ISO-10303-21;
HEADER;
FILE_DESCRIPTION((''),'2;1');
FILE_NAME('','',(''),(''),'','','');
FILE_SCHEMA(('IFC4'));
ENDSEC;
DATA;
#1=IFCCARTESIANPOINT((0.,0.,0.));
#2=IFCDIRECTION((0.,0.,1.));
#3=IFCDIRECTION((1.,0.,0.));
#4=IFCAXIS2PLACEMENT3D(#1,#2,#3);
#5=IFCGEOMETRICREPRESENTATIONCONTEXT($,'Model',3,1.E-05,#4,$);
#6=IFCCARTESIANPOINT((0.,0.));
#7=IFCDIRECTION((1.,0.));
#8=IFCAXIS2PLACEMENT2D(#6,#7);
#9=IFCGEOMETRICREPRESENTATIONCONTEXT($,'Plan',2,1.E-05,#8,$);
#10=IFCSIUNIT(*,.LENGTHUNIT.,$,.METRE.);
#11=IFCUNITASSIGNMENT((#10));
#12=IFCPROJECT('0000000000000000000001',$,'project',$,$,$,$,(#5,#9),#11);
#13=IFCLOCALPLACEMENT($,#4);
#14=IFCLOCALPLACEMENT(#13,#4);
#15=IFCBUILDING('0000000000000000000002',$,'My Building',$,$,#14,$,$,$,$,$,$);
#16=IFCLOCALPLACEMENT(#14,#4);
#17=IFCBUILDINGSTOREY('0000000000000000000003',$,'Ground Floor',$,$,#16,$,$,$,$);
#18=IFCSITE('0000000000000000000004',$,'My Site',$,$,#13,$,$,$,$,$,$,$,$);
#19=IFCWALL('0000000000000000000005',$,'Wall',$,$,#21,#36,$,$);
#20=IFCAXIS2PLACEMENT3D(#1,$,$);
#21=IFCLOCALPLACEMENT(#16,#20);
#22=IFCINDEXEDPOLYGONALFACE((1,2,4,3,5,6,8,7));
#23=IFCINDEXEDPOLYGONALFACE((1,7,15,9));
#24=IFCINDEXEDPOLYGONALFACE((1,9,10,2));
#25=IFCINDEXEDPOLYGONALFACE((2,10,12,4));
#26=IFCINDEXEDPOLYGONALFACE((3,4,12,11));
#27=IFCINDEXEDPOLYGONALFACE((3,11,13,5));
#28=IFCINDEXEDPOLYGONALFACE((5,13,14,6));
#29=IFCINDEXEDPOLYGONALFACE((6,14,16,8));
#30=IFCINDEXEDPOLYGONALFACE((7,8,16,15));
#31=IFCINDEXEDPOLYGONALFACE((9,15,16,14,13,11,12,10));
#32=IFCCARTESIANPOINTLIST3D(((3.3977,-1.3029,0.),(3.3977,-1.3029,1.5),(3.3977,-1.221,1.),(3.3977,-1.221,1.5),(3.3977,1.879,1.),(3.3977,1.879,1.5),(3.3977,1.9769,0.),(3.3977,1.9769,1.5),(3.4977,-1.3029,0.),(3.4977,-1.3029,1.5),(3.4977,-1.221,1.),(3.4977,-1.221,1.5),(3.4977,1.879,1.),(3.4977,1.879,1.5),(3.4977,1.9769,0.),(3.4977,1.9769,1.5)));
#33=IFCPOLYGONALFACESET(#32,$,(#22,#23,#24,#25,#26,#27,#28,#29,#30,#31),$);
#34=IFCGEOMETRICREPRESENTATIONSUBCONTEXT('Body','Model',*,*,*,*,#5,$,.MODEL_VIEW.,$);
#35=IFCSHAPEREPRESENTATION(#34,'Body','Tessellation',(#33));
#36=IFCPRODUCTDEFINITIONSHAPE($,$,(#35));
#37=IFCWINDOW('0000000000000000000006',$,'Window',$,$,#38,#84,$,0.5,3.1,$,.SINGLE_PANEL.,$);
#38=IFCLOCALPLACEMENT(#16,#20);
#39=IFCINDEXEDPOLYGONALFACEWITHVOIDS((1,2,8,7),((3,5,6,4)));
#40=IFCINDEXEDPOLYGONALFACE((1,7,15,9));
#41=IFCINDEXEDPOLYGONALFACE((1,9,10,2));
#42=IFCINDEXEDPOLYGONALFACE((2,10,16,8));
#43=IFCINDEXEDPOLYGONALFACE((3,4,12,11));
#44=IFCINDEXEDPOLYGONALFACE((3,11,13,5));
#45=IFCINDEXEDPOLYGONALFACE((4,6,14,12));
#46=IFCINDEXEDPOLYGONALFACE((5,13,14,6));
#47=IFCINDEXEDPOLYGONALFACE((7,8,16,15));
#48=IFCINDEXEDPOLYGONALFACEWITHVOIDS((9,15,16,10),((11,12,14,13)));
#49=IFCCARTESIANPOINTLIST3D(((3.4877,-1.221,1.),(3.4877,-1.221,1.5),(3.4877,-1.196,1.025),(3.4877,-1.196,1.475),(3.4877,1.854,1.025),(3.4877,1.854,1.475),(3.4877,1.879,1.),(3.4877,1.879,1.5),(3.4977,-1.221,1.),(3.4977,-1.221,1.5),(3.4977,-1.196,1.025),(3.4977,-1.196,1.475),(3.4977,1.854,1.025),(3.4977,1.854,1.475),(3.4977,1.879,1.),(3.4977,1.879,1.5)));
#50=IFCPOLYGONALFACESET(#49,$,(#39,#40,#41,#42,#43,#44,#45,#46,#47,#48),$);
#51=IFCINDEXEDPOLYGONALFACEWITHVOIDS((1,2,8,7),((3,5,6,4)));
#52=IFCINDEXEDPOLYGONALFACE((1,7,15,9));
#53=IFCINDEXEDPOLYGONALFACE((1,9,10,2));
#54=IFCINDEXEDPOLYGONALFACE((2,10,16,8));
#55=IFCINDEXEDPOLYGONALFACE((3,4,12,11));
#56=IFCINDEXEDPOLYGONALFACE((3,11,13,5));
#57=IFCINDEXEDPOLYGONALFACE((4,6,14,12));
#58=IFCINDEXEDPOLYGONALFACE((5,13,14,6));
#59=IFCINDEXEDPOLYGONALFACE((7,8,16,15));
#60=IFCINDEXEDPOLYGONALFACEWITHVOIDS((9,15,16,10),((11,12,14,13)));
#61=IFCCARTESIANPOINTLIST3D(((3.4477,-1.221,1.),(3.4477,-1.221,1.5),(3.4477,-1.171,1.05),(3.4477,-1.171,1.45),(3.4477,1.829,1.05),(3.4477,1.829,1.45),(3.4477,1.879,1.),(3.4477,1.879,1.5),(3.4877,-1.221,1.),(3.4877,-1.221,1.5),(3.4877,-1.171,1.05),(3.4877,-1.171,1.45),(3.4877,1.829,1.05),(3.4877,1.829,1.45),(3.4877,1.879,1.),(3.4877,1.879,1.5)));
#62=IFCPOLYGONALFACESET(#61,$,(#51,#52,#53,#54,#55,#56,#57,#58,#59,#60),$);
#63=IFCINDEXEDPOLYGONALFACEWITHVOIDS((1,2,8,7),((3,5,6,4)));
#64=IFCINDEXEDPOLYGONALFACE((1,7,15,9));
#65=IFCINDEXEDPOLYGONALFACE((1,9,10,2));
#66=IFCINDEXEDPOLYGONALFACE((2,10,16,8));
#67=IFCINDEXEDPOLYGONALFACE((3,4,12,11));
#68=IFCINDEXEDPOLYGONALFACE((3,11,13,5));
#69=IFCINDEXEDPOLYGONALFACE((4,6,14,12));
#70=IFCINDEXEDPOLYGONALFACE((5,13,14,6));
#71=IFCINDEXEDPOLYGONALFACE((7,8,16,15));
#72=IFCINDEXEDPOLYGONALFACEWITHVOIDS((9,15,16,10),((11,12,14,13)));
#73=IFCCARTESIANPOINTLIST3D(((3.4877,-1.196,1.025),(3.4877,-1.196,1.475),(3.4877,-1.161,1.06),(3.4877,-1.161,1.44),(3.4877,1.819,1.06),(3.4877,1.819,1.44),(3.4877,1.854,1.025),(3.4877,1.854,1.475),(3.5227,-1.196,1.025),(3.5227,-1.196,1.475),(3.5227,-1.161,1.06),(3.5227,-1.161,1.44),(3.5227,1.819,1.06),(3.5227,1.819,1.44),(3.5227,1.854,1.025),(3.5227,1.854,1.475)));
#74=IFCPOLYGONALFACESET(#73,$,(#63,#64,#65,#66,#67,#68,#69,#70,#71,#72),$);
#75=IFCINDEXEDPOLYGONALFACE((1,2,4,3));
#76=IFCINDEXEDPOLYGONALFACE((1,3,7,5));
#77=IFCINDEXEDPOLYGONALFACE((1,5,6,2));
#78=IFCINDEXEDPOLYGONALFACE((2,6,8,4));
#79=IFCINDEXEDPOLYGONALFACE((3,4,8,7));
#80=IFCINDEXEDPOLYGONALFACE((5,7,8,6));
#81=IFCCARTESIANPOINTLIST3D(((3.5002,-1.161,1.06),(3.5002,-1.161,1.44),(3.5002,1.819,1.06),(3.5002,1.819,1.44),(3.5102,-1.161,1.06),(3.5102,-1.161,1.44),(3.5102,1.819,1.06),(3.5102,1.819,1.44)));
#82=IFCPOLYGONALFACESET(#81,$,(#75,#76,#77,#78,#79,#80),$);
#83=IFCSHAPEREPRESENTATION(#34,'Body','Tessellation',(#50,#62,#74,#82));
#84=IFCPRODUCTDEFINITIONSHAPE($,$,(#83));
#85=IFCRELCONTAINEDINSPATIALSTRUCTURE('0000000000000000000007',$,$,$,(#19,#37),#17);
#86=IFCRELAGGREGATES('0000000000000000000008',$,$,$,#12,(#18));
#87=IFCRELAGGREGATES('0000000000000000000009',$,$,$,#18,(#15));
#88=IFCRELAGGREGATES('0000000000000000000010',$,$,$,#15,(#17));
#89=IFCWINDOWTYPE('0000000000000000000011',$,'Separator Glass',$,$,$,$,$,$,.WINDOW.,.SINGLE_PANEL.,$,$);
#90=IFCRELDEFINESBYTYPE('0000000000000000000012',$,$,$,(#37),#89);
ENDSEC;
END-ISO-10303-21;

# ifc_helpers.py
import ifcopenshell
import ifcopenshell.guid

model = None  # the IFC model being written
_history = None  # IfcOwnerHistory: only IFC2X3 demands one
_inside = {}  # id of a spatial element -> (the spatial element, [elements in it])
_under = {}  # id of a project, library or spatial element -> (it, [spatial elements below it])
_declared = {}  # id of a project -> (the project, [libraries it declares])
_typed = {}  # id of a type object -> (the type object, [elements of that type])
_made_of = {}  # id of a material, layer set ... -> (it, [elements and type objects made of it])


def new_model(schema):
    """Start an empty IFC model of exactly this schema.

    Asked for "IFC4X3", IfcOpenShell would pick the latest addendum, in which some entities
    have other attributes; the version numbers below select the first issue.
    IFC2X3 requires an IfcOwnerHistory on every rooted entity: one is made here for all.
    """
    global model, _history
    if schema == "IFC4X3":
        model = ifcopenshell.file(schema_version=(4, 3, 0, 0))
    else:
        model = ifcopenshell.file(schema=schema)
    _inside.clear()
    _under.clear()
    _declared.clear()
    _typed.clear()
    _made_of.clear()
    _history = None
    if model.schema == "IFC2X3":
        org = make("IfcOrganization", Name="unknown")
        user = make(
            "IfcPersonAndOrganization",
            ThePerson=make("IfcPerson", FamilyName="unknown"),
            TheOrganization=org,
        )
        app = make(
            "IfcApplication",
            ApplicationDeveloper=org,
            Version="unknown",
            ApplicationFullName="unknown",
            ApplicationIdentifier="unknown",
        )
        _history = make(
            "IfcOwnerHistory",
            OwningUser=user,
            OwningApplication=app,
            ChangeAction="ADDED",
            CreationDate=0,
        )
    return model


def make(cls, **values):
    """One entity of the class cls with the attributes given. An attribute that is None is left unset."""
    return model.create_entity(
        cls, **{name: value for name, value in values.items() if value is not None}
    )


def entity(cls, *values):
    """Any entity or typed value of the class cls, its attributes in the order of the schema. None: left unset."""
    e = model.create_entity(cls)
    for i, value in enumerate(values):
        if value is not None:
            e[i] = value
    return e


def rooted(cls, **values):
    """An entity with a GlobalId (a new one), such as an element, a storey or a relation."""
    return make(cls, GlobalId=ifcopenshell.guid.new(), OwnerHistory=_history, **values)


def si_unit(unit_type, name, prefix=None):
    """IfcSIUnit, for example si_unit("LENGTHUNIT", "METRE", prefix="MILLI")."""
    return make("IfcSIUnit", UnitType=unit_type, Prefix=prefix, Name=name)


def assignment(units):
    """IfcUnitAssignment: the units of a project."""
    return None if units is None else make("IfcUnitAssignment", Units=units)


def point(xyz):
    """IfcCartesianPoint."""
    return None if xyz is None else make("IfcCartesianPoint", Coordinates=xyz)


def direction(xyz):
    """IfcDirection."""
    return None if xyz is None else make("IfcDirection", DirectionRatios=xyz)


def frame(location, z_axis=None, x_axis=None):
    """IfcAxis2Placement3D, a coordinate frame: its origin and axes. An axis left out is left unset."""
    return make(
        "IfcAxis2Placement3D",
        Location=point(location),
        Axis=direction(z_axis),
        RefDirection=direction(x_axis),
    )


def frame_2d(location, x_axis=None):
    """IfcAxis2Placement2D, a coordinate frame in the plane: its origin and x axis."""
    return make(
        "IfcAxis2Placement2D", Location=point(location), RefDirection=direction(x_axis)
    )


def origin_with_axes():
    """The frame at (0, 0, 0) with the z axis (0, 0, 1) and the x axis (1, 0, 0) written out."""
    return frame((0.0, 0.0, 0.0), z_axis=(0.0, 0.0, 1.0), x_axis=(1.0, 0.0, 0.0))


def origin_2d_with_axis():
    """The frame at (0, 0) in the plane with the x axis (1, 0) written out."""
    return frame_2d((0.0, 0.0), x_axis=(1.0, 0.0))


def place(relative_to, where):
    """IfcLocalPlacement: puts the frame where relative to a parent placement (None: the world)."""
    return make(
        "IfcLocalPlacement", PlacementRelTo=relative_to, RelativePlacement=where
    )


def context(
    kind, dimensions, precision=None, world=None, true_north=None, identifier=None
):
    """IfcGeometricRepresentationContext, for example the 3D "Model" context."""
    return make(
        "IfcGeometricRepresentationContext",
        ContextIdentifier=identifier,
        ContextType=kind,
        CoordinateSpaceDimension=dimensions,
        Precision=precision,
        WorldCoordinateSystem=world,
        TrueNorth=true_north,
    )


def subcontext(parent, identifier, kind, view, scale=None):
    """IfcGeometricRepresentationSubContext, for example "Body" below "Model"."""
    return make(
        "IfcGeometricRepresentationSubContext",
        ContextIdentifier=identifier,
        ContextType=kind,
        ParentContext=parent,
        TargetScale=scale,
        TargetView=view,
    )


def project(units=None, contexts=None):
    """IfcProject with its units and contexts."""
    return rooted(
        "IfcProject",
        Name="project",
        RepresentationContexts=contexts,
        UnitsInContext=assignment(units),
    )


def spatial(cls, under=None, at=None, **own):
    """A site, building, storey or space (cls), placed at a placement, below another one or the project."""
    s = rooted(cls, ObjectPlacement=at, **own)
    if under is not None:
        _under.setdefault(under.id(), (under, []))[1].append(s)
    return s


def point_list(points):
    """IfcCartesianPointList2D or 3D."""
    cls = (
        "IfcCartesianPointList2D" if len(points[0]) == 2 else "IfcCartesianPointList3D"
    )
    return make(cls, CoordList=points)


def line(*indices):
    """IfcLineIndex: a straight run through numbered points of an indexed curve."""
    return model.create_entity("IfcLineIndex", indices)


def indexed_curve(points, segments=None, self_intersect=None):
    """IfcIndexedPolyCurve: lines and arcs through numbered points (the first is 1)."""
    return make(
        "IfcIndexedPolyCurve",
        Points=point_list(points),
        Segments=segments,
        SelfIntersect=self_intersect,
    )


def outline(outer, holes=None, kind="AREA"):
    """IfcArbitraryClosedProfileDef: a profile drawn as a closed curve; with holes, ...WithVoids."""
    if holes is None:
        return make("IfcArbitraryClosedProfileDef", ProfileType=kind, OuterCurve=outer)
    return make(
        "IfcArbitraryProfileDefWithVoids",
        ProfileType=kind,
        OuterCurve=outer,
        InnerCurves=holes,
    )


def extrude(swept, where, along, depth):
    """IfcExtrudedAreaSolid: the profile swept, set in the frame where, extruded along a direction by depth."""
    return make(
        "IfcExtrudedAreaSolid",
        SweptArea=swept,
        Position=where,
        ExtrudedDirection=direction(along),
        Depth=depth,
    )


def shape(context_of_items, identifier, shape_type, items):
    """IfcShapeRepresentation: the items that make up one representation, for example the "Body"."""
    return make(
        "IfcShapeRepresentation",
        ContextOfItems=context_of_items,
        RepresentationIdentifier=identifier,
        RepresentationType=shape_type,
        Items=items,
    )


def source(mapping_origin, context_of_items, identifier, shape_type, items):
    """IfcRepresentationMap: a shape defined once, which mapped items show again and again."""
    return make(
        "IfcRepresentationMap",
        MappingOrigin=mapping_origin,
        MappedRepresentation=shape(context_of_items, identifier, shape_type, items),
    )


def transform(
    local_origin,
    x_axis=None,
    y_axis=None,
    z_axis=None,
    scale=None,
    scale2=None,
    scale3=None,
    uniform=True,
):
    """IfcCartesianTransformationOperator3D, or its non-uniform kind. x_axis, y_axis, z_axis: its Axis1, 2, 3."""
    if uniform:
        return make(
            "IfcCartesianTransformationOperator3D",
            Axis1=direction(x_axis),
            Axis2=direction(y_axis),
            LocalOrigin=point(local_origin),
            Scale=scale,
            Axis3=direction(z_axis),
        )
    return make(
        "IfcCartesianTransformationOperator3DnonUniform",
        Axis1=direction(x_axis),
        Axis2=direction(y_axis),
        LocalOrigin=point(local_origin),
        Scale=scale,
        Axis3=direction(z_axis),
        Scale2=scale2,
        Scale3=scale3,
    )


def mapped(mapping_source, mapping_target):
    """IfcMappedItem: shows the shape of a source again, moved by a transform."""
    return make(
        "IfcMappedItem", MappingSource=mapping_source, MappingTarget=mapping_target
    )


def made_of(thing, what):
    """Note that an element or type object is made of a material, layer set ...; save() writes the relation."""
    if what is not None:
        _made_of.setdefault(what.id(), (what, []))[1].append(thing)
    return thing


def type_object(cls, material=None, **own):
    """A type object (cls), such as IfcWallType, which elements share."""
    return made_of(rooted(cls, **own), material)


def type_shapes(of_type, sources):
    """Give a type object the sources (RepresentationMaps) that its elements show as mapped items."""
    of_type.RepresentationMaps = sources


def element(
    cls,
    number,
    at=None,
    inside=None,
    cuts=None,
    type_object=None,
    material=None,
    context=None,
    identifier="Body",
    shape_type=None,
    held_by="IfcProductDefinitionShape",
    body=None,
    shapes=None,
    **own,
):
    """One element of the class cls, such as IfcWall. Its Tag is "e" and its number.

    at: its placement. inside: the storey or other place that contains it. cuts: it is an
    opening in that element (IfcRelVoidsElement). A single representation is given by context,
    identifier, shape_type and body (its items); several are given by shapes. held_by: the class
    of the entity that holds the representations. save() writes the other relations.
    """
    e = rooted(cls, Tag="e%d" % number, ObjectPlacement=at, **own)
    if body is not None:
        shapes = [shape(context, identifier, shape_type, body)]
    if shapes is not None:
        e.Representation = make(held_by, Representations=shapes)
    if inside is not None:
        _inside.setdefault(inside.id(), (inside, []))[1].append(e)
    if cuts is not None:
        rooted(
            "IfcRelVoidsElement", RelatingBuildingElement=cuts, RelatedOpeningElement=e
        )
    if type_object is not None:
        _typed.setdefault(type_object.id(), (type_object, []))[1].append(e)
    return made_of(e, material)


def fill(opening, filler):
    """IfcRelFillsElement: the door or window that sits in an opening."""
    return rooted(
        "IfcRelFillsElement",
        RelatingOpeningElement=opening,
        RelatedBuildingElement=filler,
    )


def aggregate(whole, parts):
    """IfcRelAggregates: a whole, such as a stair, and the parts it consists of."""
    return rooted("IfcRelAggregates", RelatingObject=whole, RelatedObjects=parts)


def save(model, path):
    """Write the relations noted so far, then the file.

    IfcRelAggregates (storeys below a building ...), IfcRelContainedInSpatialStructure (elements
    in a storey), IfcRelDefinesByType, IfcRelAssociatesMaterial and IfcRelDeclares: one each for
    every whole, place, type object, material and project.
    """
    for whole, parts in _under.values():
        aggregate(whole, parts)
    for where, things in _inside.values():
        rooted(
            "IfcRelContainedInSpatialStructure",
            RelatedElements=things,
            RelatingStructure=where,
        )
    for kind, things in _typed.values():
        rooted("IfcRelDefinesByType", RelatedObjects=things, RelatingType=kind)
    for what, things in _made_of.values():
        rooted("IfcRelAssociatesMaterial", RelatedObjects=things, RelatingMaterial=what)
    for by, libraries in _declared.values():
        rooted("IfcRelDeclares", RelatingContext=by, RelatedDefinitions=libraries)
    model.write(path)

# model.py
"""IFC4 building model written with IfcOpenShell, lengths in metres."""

from ifc_helpers import new_model, entity, si_unit, frame, origin_with_axes, origin_2d_with_axis, place, context, subcontext, project, spatial, line, indexed_curve, outline, extrude, shape, source, transform, mapped, type_object, type_shapes, element, fill, save


model = new_model("IFC4")

# Units and contexts
model_context = context("Model", 3, precision=1e-05, world=origin_with_axes())
plan_context = context("Plan", 2, precision=1e-05, world=origin_2d_with_axis())
body_context_1 = subcontext(model_context, "Body", "Model", "MODEL_VIEW")
body_context_2 = subcontext(plan_context, "Body", "Plan", "PLAN_VIEW")
ifc_project = project(units=[si_unit("LENGTHUNIT", "METRE")], contexts=[model_context, plan_context])

# Site, building, storey
site_placement = place(None, origin_with_axes())
site = spatial("IfcSite", under=ifc_project, at=site_placement, Name="My Site")
building_placement = place(site_placement, origin_with_axes())
building = spatial("IfcBuilding", under=site, at=building_placement, Name="My Building")
storey_placement = place(building_placement, origin_with_axes())
storey = spatial("IfcBuildingStorey", under=building, at=storey_placement, Name="Ground Floor")

# Wall, opening, window
wall_1_placement = place(storey_placement, frame((3.4977, -1.3029, 0.0), z_axis=(0.0, 0.0, 1.0), x_axis=(0.0, 1.0, 0.0)))
wall_1 = element("IfcWall", 1, at=wall_1_placement, inside=storey, Name="Wall", context=body_context_1, shape_type="SweptSolid", body=[
    extrude(outline(indexed_curve([(0.0, 0.0), (0.0, 0.1), (3.2798, 0.1), (3.2798, 0.0)], segments=[line(1, 2, 3, 4, 1)])), origin_with_axes(), (0.0, 0.0, 1.0), 1.5),
])
shared_shape_1 = source(origin_with_axes(), body_context_1, "Body", "SweptSolid", [
    extrude(outline(indexed_curve([(0.0, 0.0), (3.1, 0.0), (3.1, 0.5), (0.0, 0.5)], segments=[line(1, 2, 3, 4, 1)])), frame((0.0, -0.6, 0.0), z_axis=(0.0, -1.0, 0.0), x_axis=(1.0, 0.0, 0.0)), (0.0, 0.0, -1.0), 1.2),
])
opening_1_placement = place(wall_1_placement, frame((3.1819, 0.1, 1.0), z_axis=(0.0, 0.0, 1.0), x_axis=(-1.0, 0.0, 0.0)))
opening_1 = element("IfcOpeningElement", 2, at=opening_1_placement, cuts=wall_1, PredefinedType="OPENING", context=body_context_1, shape_type="MappedRepresentation", body=[
    mapped(shared_shape_1, transform((0.0, 0.0, 0.0), x_axis=(1.0, 0.0, 0.0), y_axis=(0.0, 1.0, 0.0), z_axis=(0.0, 0.0, 1.0), scale=1.0)),
])
window_type_1 = type_object("IfcWindowType", Name="Separator Glass", PartitioningType="SINGLE_PANEL", PredefinedType="WINDOW")
shared_shape_2 = source(origin_with_axes(), body_context_1, "Body", "SweptSolid", [
    extrude(outline(indexed_curve([(0.0, 0.0), (3.1, 0.0), (3.1, 0.5), (0.0, 0.5)], segments=[line(1, 2, 3, 4, 1)]), holes=[indexed_curve([(0.025, 0.025), (3.075, 0.025), (3.075, 0.475), (0.025, 0.475)], segments=[line(1, 2, 3, 4, 1)])]), frame((0.0, 0.09, 0.0), z_axis=(0.0, -1.0, 0.0), x_axis=(1.0, 0.0, 0.0)), (0.0, 0.0, -1.0), 0.01),
    extrude(outline(indexed_curve([(0.0, 0.0), (3.1, 0.0), (3.1, 0.5), (0.0, 0.5)], segments=[line(1, 2, 3, 4, 1)]), holes=[indexed_curve([(0.05, 0.05), (3.05, 0.05), (3.05, 0.45), (0.05, 0.45)], segments=[line(1, 2, 3, 4, 1)])]), frame((0.0, 0.05, 0.0), z_axis=(0.0, -1.0, 0.0), x_axis=(1.0, 0.0, 0.0)), (0.0, 0.0, -1.0), 0.04),
    extrude(outline(indexed_curve([(0.0, 0.0), (3.05, 0.0), (3.05, 0.45), (0.0, 0.45)], segments=[line(1, 2, 3, 4, 1)]), holes=[indexed_curve([(0.035, 0.035), (3.015, 0.035), (3.015, 0.415), (0.035, 0.415)], segments=[line(1, 2, 3, 4, 1)])]), frame((0.025, 0.09, 0.025), z_axis=(0.0, -1.0, 0.0), x_axis=(1.0, 0.0, 0.0)), (0.0, 0.0, -1.0), 0.035),
    extrude(outline(indexed_curve([(0.035, 0.035), (3.015, 0.035), (3.015, 0.415), (0.035, 0.415)], segments=[line(1, 2, 3, 4, 1)])), frame((0.025, 0.1025, 0.025), z_axis=(0.0, -1.0, 0.0), x_axis=(1.0, 0.0, 0.0)), (0.0, 0.0, -1.0), 0.01),
])
shared_shape_3 = source(origin_with_axes(), body_context_2, "Body", "Curve2D", [
    entity("IfcIndexedPolyCurve", entity("IfcCartesianPointList2D", [[0.05, 0.05], [3.05, 0.05]])),
    entity("IfcIndexedPolyCurve", entity("IfcCartesianPointList2D", [[0.0, 0.1], [0.025, 0.1], [0.025, 0.09], [0.05, 0.09], [0.05, 0.05], [0.0, 0.05]]), [entity("IfcLineIndex", [1, 2, 3, 4, 5, 6, 1])]),
    entity("IfcIndexedPolyCurve", entity("IfcCartesianPointList2D", [[3.1, 0.1], [3.075, 0.1], [3.075, 0.09], [3.05, 0.09], [3.05, 0.05], [3.1, 0.05]]), [entity("IfcLineIndex", [1, 2, 3, 4, 5, 6, 1])]),
    entity("IfcIndexedPolyCurve", entity("IfcCartesianPointList2D", [[0.025, 0.09], [0.06, 0.09], [0.06, 0.125], [0.025, 0.125]]), [entity("IfcLineIndex", [1, 2, 3, 4, 1])]),
    entity("IfcIndexedPolyCurve", entity("IfcCartesianPointList2D", [[3.075, 0.09], [3.04, 0.09], [3.04, 0.125], [3.075, 0.125]]), [entity("IfcLineIndex", [1, 2, 3, 4, 1])]),
    entity("IfcIndexedPolyCurve", entity("IfcCartesianPointList2D", [[0.06, 0.09], [3.04, 0.09]])),
    entity("IfcIndexedPolyCurve", entity("IfcCartesianPointList2D", [[0.06, 0.125], [3.04, 0.125]])),
    entity("IfcIndexedPolyCurve", entity("IfcCartesianPointList2D", [[0.06, 0.1075], [3.04, 0.1075]])),
])
type_shapes(window_type_1, [shared_shape_2, shared_shape_3])
window_1_placement = place(opening_1_placement, origin_with_axes())
window_1 = element("IfcWindow", 3, at=window_1_placement, inside=storey, type_object=window_type_1, Name="Window", OverallHeight=0.5, OverallWidth=3.1, PartitioningType="SINGLE_PANEL", shapes=[
    shape(body_context_1, "Body", "MappedRepresentation", [mapped(shared_shape_2, transform((0.0, 0.0, 0.0), x_axis=(1.0, 0.0, 0.0), y_axis=(0.0, 1.0, 0.0), z_axis=(0.0, 0.0, 1.0), scale=1.0))]),
    shape(body_context_2, "Body", "MappedRepresentation", [mapped(shared_shape_3, transform((0.0, 0.0, 0.0), x_axis=(1.0, 0.0, 0.0), y_axis=(0.0, 1.0, 0.0), z_axis=(0.0, 0.0, 1.0), scale=1.0))]),
])
fill(opening_1, window_1)

save(model, "model.ifc")
